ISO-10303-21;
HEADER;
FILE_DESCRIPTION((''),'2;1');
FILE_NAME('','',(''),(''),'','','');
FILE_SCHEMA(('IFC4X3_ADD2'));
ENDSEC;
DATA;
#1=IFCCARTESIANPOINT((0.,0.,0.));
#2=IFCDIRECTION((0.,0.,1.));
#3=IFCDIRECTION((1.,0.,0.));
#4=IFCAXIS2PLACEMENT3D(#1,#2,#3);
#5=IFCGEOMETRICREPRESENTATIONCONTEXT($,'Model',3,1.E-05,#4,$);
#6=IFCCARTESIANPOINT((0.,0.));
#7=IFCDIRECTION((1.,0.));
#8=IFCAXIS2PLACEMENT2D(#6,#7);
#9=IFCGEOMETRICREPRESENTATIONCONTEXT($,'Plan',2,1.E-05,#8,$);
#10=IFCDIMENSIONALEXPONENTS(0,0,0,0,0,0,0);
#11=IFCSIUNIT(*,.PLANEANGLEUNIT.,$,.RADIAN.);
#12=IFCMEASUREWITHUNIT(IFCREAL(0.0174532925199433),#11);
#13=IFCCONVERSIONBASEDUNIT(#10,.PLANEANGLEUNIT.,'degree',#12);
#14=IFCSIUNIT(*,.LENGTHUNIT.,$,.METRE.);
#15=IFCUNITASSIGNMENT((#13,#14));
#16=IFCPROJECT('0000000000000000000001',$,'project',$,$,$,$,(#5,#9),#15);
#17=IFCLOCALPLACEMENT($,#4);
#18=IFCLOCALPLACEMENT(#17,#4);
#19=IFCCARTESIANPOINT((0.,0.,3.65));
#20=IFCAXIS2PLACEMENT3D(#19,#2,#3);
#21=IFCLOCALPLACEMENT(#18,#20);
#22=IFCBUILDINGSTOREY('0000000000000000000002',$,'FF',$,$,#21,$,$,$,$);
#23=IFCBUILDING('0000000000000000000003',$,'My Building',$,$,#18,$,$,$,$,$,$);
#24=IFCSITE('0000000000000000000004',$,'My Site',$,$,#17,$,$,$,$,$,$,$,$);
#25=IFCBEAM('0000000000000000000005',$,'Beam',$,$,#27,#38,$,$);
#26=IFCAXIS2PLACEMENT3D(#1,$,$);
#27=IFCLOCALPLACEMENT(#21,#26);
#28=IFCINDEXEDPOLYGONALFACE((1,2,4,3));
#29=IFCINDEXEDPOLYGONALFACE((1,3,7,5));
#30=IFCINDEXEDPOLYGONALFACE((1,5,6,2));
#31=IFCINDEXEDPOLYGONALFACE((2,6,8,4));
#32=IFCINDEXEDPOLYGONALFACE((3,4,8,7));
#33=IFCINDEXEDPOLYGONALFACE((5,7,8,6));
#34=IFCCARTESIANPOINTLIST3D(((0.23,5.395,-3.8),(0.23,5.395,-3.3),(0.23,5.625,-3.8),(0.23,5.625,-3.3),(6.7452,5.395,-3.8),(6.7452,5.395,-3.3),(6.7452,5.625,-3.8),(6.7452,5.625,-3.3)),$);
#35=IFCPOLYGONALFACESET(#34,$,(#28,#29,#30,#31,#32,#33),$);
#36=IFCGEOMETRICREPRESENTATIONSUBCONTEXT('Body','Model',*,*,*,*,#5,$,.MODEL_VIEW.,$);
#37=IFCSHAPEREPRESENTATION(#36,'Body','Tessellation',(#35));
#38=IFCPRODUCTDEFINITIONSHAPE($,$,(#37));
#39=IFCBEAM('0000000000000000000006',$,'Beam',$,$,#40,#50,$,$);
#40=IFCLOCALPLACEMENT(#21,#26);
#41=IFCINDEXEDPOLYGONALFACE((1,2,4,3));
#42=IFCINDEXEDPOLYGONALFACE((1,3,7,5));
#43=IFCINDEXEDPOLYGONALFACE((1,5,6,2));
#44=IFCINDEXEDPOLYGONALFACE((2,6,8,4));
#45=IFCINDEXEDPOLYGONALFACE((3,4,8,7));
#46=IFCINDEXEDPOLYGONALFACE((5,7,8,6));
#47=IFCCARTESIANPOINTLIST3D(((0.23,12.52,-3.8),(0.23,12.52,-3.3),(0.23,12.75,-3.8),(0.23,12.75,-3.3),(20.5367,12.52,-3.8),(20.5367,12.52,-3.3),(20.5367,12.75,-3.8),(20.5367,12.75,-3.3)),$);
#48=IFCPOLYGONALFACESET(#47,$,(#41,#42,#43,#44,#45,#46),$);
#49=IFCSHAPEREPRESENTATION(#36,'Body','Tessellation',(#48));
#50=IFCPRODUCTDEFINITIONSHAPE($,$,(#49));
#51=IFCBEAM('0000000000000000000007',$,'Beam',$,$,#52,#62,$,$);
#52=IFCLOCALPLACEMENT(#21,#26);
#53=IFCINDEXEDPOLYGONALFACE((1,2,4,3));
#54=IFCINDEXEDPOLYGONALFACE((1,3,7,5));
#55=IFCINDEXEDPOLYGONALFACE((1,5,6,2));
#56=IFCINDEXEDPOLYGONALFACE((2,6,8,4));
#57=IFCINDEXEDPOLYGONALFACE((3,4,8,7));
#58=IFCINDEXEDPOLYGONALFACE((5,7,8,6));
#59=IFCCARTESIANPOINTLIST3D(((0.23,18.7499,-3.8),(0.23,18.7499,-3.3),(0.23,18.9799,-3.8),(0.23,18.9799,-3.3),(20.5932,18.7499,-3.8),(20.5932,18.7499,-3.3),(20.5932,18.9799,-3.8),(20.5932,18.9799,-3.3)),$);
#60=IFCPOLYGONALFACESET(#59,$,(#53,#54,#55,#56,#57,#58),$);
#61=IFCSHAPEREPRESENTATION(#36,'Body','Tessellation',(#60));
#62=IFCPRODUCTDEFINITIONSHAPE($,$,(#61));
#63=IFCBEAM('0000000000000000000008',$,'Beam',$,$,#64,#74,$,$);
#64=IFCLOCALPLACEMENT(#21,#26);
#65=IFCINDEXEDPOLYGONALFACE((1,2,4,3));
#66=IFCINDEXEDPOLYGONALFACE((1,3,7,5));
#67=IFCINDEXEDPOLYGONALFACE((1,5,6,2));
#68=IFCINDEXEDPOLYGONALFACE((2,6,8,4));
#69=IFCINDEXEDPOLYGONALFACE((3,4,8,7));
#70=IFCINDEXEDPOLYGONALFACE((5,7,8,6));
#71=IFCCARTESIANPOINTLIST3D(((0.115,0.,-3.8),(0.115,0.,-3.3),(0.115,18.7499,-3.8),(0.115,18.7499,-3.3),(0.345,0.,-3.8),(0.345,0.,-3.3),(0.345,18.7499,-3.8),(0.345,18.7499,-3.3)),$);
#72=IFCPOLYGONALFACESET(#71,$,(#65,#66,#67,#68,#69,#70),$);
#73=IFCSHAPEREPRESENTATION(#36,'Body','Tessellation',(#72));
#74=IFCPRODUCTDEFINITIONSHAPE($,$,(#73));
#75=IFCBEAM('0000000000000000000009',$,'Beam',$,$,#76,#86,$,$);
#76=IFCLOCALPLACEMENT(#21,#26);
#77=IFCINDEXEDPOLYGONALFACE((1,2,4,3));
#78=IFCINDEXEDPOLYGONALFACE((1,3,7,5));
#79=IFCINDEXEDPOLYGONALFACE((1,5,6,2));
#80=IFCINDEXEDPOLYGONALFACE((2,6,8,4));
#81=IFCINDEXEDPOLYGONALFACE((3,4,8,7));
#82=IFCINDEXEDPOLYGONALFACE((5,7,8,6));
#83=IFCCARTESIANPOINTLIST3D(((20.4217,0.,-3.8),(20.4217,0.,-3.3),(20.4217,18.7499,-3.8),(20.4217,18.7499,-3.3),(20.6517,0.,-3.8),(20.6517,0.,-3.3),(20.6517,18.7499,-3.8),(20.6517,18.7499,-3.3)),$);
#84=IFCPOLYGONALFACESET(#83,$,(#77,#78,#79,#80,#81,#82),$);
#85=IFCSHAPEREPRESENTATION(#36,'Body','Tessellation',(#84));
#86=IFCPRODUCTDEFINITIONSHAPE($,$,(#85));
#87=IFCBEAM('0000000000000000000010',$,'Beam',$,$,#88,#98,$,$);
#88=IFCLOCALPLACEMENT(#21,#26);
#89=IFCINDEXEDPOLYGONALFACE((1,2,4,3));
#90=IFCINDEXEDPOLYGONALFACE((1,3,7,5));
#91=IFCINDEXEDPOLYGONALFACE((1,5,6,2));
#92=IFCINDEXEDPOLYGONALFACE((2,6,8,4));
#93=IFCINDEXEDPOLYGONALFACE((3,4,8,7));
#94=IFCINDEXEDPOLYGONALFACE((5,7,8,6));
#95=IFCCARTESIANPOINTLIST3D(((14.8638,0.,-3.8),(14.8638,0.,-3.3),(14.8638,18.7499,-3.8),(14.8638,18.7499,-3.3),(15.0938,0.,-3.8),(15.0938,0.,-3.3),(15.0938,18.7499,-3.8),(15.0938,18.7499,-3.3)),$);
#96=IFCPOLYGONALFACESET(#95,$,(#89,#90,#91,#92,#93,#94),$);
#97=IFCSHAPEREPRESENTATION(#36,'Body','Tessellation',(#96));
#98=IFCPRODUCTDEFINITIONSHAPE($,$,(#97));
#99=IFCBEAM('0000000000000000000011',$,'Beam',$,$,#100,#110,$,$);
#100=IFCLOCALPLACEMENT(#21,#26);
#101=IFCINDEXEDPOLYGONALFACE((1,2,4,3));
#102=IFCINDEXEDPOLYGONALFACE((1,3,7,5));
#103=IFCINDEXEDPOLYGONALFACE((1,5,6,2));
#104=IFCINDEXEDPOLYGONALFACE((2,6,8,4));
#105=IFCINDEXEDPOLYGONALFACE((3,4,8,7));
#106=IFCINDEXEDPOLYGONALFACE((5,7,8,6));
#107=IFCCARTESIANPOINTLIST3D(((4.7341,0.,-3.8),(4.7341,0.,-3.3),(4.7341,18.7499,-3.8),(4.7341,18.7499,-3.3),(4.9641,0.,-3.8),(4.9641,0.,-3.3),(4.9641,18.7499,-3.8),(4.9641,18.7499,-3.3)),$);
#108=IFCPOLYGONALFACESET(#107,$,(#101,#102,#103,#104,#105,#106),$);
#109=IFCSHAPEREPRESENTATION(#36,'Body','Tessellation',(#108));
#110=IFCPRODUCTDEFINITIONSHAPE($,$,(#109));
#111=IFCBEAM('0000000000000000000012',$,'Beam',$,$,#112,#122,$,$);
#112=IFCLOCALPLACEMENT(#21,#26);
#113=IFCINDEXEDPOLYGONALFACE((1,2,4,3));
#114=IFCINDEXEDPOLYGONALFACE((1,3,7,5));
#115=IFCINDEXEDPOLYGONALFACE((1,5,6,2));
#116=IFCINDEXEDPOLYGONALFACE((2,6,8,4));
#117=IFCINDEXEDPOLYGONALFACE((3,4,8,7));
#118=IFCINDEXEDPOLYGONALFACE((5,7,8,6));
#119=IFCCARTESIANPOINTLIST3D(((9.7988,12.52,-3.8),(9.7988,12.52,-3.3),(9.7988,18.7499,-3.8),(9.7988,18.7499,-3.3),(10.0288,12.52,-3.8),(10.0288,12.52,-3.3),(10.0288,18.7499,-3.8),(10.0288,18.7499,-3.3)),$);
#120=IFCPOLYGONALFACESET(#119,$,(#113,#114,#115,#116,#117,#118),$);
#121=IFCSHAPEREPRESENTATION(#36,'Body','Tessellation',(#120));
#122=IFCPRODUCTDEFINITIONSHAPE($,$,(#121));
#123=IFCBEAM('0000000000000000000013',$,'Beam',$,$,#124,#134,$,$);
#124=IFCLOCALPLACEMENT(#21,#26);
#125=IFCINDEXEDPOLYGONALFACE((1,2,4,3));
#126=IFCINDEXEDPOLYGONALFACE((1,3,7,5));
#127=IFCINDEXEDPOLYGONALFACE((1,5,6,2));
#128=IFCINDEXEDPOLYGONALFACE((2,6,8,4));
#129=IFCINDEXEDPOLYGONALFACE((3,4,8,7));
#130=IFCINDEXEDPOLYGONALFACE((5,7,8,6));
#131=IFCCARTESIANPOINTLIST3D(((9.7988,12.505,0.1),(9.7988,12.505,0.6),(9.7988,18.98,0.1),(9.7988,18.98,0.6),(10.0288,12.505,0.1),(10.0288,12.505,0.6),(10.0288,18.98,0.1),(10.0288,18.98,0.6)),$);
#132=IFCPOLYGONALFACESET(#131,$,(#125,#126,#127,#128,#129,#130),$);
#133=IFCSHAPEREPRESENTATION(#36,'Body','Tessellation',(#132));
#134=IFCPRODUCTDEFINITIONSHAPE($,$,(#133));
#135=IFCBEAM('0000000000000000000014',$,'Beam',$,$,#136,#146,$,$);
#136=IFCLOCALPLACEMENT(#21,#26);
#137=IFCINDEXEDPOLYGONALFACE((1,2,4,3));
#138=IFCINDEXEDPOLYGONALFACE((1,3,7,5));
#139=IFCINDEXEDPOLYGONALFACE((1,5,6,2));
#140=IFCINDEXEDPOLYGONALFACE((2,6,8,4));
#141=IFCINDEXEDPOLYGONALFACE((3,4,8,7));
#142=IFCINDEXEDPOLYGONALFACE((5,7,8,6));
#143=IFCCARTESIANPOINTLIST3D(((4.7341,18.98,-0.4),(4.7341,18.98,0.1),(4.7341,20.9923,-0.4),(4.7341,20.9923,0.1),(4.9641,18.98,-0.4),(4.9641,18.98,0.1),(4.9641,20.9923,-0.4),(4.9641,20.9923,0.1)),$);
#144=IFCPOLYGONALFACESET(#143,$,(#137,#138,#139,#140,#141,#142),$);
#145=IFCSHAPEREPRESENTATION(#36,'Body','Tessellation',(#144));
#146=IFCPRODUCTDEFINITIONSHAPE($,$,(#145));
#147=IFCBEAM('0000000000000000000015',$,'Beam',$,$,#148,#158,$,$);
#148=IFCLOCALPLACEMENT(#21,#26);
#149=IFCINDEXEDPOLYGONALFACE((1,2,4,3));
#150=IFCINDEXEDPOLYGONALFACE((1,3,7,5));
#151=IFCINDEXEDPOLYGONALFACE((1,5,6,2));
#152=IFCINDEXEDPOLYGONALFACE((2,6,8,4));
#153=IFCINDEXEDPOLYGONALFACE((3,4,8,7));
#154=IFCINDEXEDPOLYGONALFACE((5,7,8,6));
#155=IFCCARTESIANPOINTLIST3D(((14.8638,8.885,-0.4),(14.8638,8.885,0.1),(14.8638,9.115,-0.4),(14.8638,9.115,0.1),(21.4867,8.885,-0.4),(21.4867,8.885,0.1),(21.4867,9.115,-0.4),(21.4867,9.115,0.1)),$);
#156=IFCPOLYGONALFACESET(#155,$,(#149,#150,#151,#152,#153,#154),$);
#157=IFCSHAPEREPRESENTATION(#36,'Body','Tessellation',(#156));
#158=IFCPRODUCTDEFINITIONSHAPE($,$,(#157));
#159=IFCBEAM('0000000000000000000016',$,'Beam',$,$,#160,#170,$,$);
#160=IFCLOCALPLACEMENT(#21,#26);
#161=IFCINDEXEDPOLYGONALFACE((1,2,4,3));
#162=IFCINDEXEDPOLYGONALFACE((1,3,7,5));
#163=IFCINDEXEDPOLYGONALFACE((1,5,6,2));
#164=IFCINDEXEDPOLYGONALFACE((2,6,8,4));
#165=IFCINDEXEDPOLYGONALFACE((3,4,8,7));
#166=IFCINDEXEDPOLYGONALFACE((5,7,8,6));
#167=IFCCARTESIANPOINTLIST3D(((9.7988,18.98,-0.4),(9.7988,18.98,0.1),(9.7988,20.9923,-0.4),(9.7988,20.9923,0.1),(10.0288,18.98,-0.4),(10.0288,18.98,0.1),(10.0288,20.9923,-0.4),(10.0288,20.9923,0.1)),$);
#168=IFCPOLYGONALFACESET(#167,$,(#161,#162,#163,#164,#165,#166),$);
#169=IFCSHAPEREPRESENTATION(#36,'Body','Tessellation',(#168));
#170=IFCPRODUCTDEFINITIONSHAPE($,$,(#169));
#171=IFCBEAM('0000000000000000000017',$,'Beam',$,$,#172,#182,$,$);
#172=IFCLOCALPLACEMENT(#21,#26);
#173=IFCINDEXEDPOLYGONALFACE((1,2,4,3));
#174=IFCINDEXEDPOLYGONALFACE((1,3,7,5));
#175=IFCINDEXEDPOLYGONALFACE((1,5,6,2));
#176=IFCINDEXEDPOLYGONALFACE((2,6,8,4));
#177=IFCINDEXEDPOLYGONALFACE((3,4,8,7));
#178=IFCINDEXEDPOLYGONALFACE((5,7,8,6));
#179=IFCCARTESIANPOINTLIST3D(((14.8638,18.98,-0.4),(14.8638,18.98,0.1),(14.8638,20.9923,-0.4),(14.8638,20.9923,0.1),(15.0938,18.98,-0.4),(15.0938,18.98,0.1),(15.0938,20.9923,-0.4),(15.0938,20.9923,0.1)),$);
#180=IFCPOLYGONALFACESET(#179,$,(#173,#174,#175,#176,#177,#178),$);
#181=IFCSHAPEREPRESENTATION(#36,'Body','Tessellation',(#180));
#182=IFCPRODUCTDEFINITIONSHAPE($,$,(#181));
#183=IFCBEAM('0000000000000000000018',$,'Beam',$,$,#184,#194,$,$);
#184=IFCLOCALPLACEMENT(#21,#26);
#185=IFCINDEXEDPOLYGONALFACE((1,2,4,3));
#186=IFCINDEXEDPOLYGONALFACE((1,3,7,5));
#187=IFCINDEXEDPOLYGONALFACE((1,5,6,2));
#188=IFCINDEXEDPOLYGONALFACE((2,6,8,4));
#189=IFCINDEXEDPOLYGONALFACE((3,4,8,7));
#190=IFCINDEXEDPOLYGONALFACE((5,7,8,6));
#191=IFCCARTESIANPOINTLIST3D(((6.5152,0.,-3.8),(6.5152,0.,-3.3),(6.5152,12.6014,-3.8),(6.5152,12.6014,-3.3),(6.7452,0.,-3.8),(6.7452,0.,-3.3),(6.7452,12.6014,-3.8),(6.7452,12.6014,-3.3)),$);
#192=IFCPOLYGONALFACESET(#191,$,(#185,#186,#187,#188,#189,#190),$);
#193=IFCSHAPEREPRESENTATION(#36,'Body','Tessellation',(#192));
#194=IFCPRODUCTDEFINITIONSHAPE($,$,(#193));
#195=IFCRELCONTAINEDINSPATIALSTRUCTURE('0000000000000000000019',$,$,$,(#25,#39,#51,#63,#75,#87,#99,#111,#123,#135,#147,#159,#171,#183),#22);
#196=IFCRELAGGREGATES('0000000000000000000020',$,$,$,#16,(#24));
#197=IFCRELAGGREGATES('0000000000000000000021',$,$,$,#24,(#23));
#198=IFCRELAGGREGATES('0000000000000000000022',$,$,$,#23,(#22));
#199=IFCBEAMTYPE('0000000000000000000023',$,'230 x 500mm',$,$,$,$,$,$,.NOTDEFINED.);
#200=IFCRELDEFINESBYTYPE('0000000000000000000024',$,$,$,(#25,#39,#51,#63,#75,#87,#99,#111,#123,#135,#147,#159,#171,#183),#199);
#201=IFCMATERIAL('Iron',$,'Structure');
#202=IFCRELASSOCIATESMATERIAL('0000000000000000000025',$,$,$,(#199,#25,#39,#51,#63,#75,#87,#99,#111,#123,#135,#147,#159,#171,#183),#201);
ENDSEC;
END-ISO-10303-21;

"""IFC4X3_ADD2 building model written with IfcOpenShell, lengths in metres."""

from ifc_helpers import new_model, entity, si_unit, converted_unit, frame, origin_with_axes, origin_2d_with_axis, place, context, subcontext, project, spatial, rectangle, extrude, material, material_profile, profile_set, profile_usage, type_object, element, save


model = new_model("IFC4X3_ADD2")

# Units and contexts
model_context = context("Model", 3, precision=1e-05, world=origin_with_axes())
plan_context = context("Plan", 2, precision=1e-05, world=origin_2d_with_axis())
body_context = subcontext(model_context, "Body", "Model", "MODEL_VIEW")
ifc_project = project(units=[converted_unit("PLANEANGLEUNIT", "degree", entity("IfcReal", 0.0174532925199433), si_unit("PLANEANGLEUNIT", "RADIAN"), dimensions=[0, 0, 0, 0, 0, 0, 0]), si_unit("LENGTHUNIT", "METRE")], contexts=[model_context, plan_context])

# Site, building, storey
site_placement = place(None, origin_with_axes())
site = spatial("IfcSite", under=ifc_project, at=site_placement, Name="My Site")
building_placement = place(site_placement, origin_with_axes())
building = spatial("IfcBuilding", under=site, at=building_placement, Name="My Building")
storey_placement = place(building_placement, frame((0.0, 0.0, 3.65), z_axis=(0.0, 0.0, 1.0), x_axis=(1.0, 0.0, 0.0)))
storey = spatial("IfcBuildingStorey", under=building, at=storey_placement, Name="FF")

# Beams
ifc_material_1 = material(Name="Iron", Category="Structure")
ifc_material_profile_1 = material_profile(ifc_material_1, rectangle(XDim=0.23, YDim=0.5))
ifc_profile_set_1 = profile_set([ifc_material_profile_1])
beam_type_1 = type_object("IfcBeamType", Name="230 x 500mm", PredefinedType="NOTDEFINED", material=ifc_profile_set_1)
ifc_profile_usage_1 = profile_usage(ifc_profile_set_1)
beam_1_placement = place(storey_placement, frame((0.23, 5.51, -3.55), z_axis=(1.0, 0.0, 0.0), x_axis=(0.0, 1.0, 0.0)))
element("IfcBeam", 1, at=beam_1_placement, inside=storey, type_object=beam_type_1, material=ifc_profile_usage_1, Name="Beam", context=body_context, shape_type="SweptSolid", body=[
    extrude(rectangle(XDim=0.23, YDim=0.5), origin_with_axes(), (0.0, 0.0, 1.0), 6.5152),
])
ifc_profile_usage_2 = profile_usage(ifc_profile_set_1)
beam_2_placement = place(storey_placement, frame((0.23, 12.635, -3.55), z_axis=(1.0, 0.0, 0.0), x_axis=(0.0, 1.0, 0.0)))
element("IfcBeam", 2, at=beam_2_placement, inside=storey, type_object=beam_type_1, material=ifc_profile_usage_2, Name="Beam", context=body_context, shape_type="SweptSolid", body=[
    extrude(rectangle(XDim=0.23, YDim=0.5), origin_with_axes(), (0.0, 0.0, 1.0), 20.3067),
])
ifc_profile_usage_3 = profile_usage(ifc_profile_set_1)
beam_3_placement = place(storey_placement, frame((0.23, 18.8649, -3.55), z_axis=(1.0, 0.0, 0.0), x_axis=(0.0, 1.0, 0.0)))
element("IfcBeam", 3, at=beam_3_placement, inside=storey, type_object=beam_type_1, material=ifc_profile_usage_3, Name="Beam", context=body_context, shape_type="SweptSolid", body=[
    extrude(rectangle(XDim=0.23, YDim=0.5), origin_with_axes(), (0.0, 0.0, 1.0), 20.3632),
])
ifc_profile_usage_4 = profile_usage(ifc_profile_set_1)
beam_4_placement = place(storey_placement, frame((0.23, 0.0, -3.55), z_axis=(0.0, 1.0, 0.0), x_axis=(-1.0, 0.0, 0.0)))
element("IfcBeam", 4, at=beam_4_placement, inside=storey, type_object=beam_type_1, material=ifc_profile_usage_4, Name="Beam", context=body_context, shape_type="SweptSolid", body=[
    extrude(rectangle(XDim=0.23, YDim=0.5), origin_with_axes(), (0.0, 0.0, 1.0), 18.7499),
])
ifc_profile_usage_5 = profile_usage(ifc_profile_set_1)
beam_5_placement = place(storey_placement, frame((20.5367, 0.0, -3.55), z_axis=(0.0, 1.0, 0.0), x_axis=(-1.0, 0.0, 0.0)))
element("IfcBeam", 5, at=beam_5_placement, inside=storey, type_object=beam_type_1, material=ifc_profile_usage_5, Name="Beam", context=body_context, shape_type="SweptSolid", body=[
    extrude(rectangle(XDim=0.23, YDim=0.5), origin_with_axes(), (0.0, 0.0, 1.0), 18.7499),
])
ifc_profile_usage_6 = profile_usage(ifc_profile_set_1)
beam_6_placement = place(storey_placement, frame((14.9788, 0.0, -3.55), z_axis=(0.0, 1.0, 0.0), x_axis=(-1.0, 0.0, 0.0)))
element("IfcBeam", 6, at=beam_6_placement, inside=storey, type_object=beam_type_1, material=ifc_profile_usage_6, Name="Beam", context=body_context, shape_type="SweptSolid", body=[
    extrude(rectangle(XDim=0.23, YDim=0.5), origin_with_axes(), (0.0, 0.0, 1.0), 18.7499),
])
ifc_profile_usage_7 = profile_usage(ifc_profile_set_1)
beam_7_placement = place(storey_placement, frame((4.8491, 0.0, -3.55), z_axis=(0.0, 1.0, 0.0), x_axis=(-1.0, 0.0, 0.0)))
element("IfcBeam", 7, at=beam_7_placement, inside=storey, type_object=beam_type_1, material=ifc_profile_usage_7, Name="Beam", context=body_context, shape_type="SweptSolid", body=[
    extrude(rectangle(XDim=0.23, YDim=0.5), origin_with_axes(), (0.0, 0.0, 1.0), 18.7499),
])
ifc_profile_usage_8 = profile_usage(ifc_profile_set_1)
beam_8_placement = place(storey_placement, frame((9.9138, 12.52, -3.55), z_axis=(0.0, 1.0, 0.0), x_axis=(-1.0, 0.0, 0.0)))
element("IfcBeam", 8, at=beam_8_placement, inside=storey, type_object=beam_type_1, material=ifc_profile_usage_8, Name="Beam", context=body_context, shape_type="SweptSolid", body=[
    extrude(rectangle(XDim=0.23, YDim=0.5), origin_with_axes(), (0.0, 0.0, 1.0), 6.2299),
])
ifc_profile_usage_9 = profile_usage(ifc_profile_set_1)
beam_9_placement = place(storey_placement, frame((9.9138, 18.98, 0.35), z_axis=(0.0, -1.0, 0.0), x_axis=(1.0, 0.0, 0.0)))
element("IfcBeam", 9, at=beam_9_placement, inside=storey, type_object=beam_type_1, material=ifc_profile_usage_9, Name="Beam", context=body_context, shape_type="SweptSolid", body=[
    extrude(rectangle(XDim=0.23, YDim=0.5), origin_with_axes(), (0.0, 0.0, 1.0), 6.475),
])
ifc_profile_usage_10 = profile_usage(ifc_profile_set_1)
beam_10_placement = place(storey_placement, frame((4.8491, 20.9923, -0.15), z_axis=(0.0, -1.0, 0.0), x_axis=(1.0, 0.0, 0.0)))
element("IfcBeam", 10, at=beam_10_placement, inside=storey, type_object=beam_type_1, material=ifc_profile_usage_10, Name="Beam", context=body_context, shape_type="SweptSolid", body=[
    extrude(rectangle(XDim=0.23, YDim=0.5), origin_with_axes(), (0.0, 0.0, 1.0), 2.0123),
])
ifc_profile_usage_11 = profile_usage(ifc_profile_set_1)
beam_11_placement = place(storey_placement, frame((14.8638, 9.0, -0.15), z_axis=(1.0, 0.0, 0.0), x_axis=(0.0, 1.0, 0.0)))
element("IfcBeam", 11, at=beam_11_placement, inside=storey, type_object=beam_type_1, material=ifc_profile_usage_11, Name="Beam", context=body_context, shape_type="SweptSolid", body=[
    extrude(rectangle(XDim=0.23, YDim=0.5), origin_with_axes(), (0.0, 0.0, 1.0), 6.6229),
])
ifc_profile_usage_12 = profile_usage(ifc_profile_set_1)
beam_12_placement = place(storey_placement, frame((9.9138, 20.9923, -0.15), z_axis=(0.0, -1.0, 0.0), x_axis=(1.0, 0.0, 0.0)))
element("IfcBeam", 12, at=beam_12_placement, inside=storey, type_object=beam_type_1, material=ifc_profile_usage_12, Name="Beam", context=body_context, shape_type="SweptSolid", body=[
    extrude(rectangle(XDim=0.23, YDim=0.5), origin_with_axes(), (0.0, 0.0, 1.0), 2.0123),
])
ifc_profile_usage_13 = profile_usage(ifc_profile_set_1)
beam_13_placement = place(storey_placement, frame((14.9788, 20.9923, -0.15), z_axis=(0.0, -1.0, 0.0), x_axis=(1.0, 0.0, 0.0)))
element("IfcBeam", 13, at=beam_13_placement, inside=storey, type_object=beam_type_1, material=ifc_profile_usage_13, Name="Beam", context=body_context, shape_type="SweptSolid", body=[
    extrude(rectangle(XDim=0.23, YDim=0.5), origin_with_axes(), (0.0, 0.0, 1.0), 2.0123),
])
ifc_profile_usage_14 = profile_usage(ifc_profile_set_1)
beam_14_placement = place(storey_placement, frame((6.6302, 0.0, -3.55), z_axis=(0.0, 1.0, 0.0), x_axis=(-1.0, 0.0, 0.0)))
element("IfcBeam", 14, at=beam_14_placement, inside=storey, type_object=beam_type_1, material=ifc_profile_usage_14, Name="Beam", context=body_context, shape_type="SweptSolid", body=[
    extrude(rectangle(XDim=0.23, YDim=0.5), origin_with_axes(), (0.0, 0.0, 1.0), 12.6014),
])

save(model, "model.ifc")
